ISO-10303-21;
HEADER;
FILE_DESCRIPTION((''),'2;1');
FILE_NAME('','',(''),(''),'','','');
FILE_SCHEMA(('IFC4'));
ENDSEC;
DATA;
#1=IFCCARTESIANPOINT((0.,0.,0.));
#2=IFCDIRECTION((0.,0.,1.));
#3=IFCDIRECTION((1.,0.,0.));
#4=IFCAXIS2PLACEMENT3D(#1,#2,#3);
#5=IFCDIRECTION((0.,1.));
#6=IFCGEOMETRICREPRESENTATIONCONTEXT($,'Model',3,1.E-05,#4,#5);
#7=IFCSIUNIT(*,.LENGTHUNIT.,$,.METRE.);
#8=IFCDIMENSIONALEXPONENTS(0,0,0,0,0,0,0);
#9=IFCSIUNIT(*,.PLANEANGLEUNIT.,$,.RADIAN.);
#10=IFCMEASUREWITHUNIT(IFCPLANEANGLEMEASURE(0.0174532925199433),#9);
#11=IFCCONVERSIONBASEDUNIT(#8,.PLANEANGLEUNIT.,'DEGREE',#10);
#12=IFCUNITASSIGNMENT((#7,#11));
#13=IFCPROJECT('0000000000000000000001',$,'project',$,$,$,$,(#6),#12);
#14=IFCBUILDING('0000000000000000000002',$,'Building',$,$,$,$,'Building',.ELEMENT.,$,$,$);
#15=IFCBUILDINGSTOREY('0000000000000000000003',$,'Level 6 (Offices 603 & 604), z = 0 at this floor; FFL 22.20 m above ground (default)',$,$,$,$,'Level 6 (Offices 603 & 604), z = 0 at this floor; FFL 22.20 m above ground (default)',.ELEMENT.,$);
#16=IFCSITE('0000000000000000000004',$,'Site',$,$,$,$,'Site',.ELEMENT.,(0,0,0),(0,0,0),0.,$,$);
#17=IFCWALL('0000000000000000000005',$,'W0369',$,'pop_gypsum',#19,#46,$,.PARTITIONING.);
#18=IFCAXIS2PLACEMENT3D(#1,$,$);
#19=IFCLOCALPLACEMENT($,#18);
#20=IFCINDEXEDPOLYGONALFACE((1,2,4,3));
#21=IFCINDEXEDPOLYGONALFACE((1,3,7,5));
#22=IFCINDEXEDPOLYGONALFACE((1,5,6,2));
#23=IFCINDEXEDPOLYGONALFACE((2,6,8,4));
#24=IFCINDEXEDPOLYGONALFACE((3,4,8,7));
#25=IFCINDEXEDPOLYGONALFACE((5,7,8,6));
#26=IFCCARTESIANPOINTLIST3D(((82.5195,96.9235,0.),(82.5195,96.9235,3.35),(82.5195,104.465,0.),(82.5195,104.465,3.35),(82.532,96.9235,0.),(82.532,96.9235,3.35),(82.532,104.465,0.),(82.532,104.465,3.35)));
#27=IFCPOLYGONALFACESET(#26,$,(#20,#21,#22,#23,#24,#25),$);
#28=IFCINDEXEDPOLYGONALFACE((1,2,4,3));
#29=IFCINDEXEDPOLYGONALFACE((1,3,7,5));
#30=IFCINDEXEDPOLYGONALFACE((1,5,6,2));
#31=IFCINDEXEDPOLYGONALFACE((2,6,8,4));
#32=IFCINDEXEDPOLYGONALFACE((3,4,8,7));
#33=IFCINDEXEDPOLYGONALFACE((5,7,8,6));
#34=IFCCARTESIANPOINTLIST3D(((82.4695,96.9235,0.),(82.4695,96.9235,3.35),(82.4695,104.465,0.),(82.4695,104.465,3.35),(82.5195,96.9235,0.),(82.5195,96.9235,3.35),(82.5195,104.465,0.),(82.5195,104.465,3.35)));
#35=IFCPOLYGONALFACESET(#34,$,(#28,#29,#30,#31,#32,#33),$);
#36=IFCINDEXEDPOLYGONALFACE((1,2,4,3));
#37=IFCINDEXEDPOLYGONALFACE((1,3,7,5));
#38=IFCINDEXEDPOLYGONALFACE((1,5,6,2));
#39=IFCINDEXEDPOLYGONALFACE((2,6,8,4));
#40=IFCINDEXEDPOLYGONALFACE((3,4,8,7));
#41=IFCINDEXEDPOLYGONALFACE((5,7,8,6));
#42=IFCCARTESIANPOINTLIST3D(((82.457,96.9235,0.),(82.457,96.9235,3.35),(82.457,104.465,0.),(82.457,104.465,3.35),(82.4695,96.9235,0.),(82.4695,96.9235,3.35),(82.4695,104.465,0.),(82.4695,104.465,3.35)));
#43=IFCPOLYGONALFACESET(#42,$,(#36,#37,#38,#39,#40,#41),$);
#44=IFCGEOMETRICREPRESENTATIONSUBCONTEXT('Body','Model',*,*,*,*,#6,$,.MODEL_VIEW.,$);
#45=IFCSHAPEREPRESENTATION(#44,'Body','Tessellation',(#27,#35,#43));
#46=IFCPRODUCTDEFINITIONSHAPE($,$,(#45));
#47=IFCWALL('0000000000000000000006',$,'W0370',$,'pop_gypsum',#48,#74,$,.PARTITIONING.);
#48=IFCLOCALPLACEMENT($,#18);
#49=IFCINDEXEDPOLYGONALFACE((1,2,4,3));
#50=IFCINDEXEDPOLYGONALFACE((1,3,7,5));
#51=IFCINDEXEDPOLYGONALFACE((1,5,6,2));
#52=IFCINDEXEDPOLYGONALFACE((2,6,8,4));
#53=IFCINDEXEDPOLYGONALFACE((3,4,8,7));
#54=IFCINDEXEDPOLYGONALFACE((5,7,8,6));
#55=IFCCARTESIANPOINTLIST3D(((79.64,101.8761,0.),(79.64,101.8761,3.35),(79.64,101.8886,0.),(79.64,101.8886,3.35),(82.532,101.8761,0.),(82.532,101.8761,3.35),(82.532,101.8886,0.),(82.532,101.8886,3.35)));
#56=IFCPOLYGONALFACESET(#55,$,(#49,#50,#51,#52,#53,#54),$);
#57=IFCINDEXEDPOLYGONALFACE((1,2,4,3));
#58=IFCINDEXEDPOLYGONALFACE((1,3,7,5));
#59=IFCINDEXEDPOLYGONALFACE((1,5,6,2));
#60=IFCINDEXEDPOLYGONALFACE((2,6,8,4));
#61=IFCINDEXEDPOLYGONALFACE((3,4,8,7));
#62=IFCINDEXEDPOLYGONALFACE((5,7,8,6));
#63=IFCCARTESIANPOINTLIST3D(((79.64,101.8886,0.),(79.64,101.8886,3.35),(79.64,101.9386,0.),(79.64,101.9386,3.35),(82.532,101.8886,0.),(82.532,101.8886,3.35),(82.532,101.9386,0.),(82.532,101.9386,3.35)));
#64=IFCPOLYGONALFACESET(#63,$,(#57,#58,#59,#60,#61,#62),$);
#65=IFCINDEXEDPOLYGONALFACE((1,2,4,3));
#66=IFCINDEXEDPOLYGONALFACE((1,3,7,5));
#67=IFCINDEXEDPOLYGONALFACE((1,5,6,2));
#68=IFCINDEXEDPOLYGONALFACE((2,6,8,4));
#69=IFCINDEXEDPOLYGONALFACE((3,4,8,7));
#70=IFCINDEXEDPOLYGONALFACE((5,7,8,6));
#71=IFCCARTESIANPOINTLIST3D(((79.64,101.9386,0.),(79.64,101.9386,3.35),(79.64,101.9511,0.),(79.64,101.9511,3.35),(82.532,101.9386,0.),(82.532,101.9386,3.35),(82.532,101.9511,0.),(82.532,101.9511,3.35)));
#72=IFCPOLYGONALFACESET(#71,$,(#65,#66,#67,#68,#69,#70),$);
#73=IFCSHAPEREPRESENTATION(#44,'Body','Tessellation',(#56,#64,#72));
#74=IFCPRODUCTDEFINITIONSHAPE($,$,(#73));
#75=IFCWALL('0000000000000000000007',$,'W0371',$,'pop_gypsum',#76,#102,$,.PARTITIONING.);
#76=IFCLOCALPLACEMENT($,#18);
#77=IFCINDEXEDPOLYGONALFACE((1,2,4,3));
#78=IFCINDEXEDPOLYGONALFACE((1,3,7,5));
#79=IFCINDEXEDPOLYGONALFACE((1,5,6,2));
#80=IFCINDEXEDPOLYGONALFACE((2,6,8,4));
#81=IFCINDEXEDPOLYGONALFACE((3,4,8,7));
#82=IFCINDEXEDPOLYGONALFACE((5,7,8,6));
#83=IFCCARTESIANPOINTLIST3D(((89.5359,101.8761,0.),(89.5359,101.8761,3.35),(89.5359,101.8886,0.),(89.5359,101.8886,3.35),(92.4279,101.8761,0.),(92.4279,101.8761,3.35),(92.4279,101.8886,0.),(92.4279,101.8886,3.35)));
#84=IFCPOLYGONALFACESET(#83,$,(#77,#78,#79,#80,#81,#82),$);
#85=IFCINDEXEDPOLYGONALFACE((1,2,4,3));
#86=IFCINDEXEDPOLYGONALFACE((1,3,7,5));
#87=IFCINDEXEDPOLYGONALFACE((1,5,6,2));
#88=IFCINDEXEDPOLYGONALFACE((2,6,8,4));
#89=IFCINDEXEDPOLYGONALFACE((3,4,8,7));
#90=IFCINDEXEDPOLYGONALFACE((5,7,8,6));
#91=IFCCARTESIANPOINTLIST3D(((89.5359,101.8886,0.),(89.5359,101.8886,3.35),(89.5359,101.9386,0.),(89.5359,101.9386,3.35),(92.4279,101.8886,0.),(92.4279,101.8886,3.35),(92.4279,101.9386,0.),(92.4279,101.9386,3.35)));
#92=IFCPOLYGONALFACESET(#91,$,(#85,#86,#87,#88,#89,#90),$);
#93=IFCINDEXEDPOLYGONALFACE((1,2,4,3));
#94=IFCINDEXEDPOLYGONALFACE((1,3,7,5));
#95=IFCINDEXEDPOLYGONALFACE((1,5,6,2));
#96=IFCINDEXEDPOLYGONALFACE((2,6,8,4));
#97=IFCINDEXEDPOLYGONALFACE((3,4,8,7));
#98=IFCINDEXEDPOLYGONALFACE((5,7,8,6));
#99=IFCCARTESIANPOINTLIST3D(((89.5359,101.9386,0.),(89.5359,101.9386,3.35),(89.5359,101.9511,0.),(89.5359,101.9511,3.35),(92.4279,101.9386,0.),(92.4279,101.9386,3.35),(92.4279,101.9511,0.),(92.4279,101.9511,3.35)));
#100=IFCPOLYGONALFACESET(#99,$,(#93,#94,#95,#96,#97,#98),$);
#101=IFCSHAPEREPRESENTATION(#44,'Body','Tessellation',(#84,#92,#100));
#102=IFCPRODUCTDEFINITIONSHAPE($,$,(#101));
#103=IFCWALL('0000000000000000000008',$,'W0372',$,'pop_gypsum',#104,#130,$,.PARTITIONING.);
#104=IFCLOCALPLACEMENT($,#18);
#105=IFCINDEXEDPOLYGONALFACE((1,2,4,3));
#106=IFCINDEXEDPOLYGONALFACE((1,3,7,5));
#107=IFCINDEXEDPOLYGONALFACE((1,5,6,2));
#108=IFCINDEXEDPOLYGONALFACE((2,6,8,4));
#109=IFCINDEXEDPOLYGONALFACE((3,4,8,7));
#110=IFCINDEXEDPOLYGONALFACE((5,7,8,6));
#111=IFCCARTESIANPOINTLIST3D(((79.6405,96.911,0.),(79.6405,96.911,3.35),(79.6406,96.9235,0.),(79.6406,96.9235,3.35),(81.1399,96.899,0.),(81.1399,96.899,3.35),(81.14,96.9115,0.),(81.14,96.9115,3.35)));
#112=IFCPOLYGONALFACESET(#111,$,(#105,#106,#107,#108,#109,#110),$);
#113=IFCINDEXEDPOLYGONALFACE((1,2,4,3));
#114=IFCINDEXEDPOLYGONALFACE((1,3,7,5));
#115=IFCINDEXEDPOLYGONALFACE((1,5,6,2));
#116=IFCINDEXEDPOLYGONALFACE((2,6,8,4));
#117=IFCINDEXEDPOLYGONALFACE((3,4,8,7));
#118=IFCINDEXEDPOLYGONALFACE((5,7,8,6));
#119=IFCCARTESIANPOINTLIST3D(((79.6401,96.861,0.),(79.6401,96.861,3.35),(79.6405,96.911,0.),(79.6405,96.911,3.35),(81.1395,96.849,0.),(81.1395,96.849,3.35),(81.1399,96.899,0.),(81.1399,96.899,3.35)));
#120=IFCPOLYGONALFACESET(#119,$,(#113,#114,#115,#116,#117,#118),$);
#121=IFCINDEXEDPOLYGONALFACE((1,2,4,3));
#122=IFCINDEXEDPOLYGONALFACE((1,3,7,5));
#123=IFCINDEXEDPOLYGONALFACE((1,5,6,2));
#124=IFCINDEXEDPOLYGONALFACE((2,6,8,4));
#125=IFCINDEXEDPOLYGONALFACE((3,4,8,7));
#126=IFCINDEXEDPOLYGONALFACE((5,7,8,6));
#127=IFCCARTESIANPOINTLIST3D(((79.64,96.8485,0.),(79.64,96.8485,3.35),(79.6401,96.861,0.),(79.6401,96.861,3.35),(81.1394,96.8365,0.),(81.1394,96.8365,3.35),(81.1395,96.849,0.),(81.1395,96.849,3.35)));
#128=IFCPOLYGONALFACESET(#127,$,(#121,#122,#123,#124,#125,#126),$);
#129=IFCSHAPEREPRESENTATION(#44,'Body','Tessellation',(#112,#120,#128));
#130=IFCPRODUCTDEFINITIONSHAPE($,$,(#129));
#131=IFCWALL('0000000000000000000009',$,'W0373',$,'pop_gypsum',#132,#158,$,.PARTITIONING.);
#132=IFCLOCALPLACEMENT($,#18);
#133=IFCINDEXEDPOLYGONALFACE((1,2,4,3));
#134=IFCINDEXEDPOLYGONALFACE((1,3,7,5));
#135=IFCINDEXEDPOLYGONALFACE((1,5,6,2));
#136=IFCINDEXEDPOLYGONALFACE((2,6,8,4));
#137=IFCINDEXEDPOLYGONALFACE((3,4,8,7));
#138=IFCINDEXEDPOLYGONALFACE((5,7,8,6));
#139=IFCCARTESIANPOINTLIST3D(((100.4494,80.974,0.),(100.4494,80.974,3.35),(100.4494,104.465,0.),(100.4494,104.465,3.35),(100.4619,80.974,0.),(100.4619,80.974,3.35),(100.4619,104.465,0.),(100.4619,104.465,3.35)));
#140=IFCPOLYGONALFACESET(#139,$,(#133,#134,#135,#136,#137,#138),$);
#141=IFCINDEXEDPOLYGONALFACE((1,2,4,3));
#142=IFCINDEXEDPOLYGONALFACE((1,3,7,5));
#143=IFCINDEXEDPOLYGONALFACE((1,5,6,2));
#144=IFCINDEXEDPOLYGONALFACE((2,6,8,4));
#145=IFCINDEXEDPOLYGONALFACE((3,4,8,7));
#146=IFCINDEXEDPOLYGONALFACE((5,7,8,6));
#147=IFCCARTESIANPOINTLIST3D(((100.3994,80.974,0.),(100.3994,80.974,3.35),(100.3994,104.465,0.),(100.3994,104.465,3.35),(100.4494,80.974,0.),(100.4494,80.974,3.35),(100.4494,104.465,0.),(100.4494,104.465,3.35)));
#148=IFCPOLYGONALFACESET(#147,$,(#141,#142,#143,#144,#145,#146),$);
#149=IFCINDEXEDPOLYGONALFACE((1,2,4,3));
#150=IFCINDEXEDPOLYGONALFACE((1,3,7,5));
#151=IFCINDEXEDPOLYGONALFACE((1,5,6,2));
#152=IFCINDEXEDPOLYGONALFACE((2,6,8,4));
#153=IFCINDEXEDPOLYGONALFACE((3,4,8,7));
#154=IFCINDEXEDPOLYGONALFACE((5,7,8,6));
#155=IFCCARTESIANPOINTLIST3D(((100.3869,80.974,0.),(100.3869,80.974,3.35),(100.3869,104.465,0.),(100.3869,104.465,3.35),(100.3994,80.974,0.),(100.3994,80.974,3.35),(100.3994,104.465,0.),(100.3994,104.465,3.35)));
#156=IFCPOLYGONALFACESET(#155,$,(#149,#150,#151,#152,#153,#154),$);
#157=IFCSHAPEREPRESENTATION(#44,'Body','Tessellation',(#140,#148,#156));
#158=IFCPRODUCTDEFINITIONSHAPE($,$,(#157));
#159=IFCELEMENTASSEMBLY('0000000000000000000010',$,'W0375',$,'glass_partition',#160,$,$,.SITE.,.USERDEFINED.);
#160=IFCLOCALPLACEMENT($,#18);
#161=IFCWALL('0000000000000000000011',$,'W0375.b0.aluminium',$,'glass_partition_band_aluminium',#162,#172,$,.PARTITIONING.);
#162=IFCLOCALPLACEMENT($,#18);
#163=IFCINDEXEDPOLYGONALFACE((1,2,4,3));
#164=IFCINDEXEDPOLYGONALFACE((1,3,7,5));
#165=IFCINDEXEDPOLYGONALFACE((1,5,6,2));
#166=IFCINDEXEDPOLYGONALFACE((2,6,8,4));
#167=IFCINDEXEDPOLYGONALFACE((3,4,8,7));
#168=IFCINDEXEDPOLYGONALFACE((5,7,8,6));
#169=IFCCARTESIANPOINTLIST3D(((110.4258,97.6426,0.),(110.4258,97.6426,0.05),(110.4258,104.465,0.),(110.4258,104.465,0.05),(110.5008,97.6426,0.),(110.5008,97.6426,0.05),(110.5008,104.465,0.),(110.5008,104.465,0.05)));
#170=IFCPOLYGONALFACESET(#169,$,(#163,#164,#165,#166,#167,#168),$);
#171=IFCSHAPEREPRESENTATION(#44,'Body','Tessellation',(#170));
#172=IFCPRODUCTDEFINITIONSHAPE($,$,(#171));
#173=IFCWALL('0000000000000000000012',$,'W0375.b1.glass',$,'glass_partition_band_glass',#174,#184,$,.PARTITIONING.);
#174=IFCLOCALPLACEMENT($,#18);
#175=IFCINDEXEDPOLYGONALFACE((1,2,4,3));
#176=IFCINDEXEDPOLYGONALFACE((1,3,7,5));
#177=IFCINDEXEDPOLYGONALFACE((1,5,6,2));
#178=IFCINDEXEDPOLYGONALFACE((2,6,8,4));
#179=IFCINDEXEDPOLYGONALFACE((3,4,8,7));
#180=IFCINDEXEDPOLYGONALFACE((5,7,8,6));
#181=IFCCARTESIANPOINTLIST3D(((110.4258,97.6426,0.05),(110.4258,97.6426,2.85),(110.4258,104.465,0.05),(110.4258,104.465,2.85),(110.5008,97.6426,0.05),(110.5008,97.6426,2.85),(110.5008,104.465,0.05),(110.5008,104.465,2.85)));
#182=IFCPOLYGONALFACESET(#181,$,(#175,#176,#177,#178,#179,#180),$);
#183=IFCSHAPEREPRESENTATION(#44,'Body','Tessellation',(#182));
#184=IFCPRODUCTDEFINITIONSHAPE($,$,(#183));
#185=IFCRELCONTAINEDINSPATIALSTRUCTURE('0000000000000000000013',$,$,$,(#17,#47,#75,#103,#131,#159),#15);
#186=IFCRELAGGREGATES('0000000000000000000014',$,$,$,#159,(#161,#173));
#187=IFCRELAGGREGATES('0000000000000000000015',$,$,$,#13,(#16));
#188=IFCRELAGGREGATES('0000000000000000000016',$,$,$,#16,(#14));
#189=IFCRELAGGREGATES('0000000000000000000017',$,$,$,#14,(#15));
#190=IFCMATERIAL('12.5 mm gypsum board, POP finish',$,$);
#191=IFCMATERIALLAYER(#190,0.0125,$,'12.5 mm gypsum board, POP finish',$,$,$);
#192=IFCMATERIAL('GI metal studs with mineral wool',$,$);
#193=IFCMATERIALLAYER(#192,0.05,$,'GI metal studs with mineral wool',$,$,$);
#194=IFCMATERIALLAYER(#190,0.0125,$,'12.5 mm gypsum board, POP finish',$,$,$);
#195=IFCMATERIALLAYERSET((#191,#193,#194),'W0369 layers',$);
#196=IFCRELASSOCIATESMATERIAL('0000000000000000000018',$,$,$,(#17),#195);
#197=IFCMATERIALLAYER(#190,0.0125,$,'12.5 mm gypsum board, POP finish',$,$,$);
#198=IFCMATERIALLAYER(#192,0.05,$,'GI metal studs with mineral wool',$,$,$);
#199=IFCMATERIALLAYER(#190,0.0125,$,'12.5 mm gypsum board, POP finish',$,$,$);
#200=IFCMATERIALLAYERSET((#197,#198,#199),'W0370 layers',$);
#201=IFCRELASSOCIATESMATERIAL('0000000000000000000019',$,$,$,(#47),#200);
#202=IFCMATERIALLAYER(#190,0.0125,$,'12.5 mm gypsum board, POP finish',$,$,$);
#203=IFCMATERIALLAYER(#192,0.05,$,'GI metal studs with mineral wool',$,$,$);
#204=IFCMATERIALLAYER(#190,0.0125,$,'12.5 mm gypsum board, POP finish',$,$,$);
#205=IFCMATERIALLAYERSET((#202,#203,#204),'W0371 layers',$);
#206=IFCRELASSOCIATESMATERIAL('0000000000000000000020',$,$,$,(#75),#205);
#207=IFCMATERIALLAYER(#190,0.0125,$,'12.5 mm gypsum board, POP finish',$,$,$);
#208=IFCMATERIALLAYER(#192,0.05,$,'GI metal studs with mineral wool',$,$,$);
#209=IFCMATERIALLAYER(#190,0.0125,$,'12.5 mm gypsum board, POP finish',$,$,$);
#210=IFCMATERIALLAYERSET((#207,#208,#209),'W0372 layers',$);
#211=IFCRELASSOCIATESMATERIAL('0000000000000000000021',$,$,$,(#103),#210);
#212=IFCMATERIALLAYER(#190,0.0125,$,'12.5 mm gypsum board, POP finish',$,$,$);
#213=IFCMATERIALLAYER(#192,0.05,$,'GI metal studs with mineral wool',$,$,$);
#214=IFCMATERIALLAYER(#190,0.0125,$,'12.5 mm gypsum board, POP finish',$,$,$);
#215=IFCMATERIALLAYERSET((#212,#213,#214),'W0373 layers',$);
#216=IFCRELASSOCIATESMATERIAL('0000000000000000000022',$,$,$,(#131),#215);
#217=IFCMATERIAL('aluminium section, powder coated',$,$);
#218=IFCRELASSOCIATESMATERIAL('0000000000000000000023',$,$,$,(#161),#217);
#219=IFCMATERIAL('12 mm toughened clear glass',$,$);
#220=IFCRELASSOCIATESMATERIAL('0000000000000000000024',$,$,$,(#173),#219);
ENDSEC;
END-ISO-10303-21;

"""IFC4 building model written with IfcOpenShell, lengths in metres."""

from ifc_helpers import new_model, entity, si_unit, converted_unit, direction, frame, frame_2d, origin_with_axes, place, context, subcontext, project, spatial, rectangle, extrude, material, layer, layer_set, layer_usage, element, aggregate, save


model = new_model("IFC4")

# Units and contexts
model_context = context("Model", 3, precision=1e-05, world=origin_with_axes(), true_north=direction((0.0, 1.0)))
body_context = subcontext(model_context, "Body", "Model", "MODEL_VIEW")
ifc_project = project(units=[si_unit("LENGTHUNIT", "METRE"), converted_unit("PLANEANGLEUNIT", "DEGREE", entity("IfcPlaneAngleMeasure", 0.0174532925199433), si_unit("PLANEANGLEUNIT", "RADIAN"), dimensions=[0, 0, 0, 0, 0, 0, 0])], contexts=[model_context])

# Site, building, storey
site = spatial("IfcSite", under=ifc_project, Name="Site", LongName="Site", CompositionType="ELEMENT", RefLatitude=(0, 0, 0), RefLongitude=(0, 0, 0), RefElevation=0.0)
building = spatial("IfcBuilding", under=site, Name="Building", LongName="Building", CompositionType="ELEMENT")
storey = spatial("IfcBuildingStorey", under=building, Name="Level 6 (Offices 603 & 604), z = 0 at this floor; FFL 22.20 m above ground (default)", LongName="Level 6 (Offices 603 & 604), z = 0 at this floor; FFL 22.20 m above ground (default)", CompositionType="ELEMENT")

# Shared definitions
ifc_material_1 = material(Name="aluminium section, powder coated")
placement = place(None, origin_with_axes())

# Shared definitions
ifc_material_2 = material(Name="12 mm toughened clear glass")

# Shared definitions
ifc_material_3 = material(Name="12.5 mm gypsum board, POP finish")
ifc_material_4 = material(Name="GI metal studs with mineral wool")

# Walls
ifc_layer_1 = layer(ifc_material_3, 0.0125, Name="12.5 mm gypsum board, POP finish")
ifc_layer_2 = layer(ifc_material_4, 0.05, Name="GI metal studs with mineral wool")
ifc_layer_3 = layer(ifc_material_3, 0.0125, Name="12.5 mm gypsum board, POP finish")
ifc_layer_set_1 = layer_set([ifc_layer_1, ifc_layer_2, ifc_layer_3], Name="W0369 layers")
ifc_layer_usage_1 = layer_usage(ifc_layer_set_1, "AXIS2", "POSITIVE", -0.0375)
element("IfcWall", 1, at=placement, inside=storey, material=ifc_layer_usage_1, Name="W0369", ObjectType="pop_gypsum", PredefinedType="PARTITIONING", context=body_context, shape_type="SweptSolid", body=[
    extrude(rectangle(XDim=7.5415, YDim=0.0125, at=frame_2d((0.0, 0.0), x_axis=(0.0, 1.0))), frame((82.5258, 100.6942, 0.0), z_axis=(0.0, 0.0, 1.0), x_axis=(1.0, 0.0, 0.0)), (0.0, 0.0, 1.0), 3.35),
    extrude(rectangle(XDim=7.5415, YDim=0.05, at=frame_2d((-0.0312, 0.0), x_axis=(0.0, 1.0))), frame((82.5258, 100.6942, 0.0), z_axis=(0.0, 0.0, 1.0), x_axis=(1.0, 0.0, 0.0)), (0.0, 0.0, 1.0), 3.35),
    extrude(rectangle(XDim=7.5415, YDim=0.0125, at=frame_2d((-0.0625, 0.0), x_axis=(0.0, 1.0))), frame((82.5258, 100.6942, 0.0), z_axis=(0.0, 0.0, 1.0), x_axis=(1.0, 0.0, 0.0)), (0.0, 0.0, 1.0), 3.35),
])
ifc_layer_4 = layer(ifc_material_3, 0.0125, Name="12.5 mm gypsum board, POP finish")
ifc_layer_5 = layer(ifc_material_4, 0.05, Name="GI metal studs with mineral wool")
ifc_layer_6 = layer(ifc_material_3, 0.0125, Name="12.5 mm gypsum board, POP finish")
ifc_layer_set_2 = layer_set([ifc_layer_4, ifc_layer_5, ifc_layer_6], Name="W0370 layers")
ifc_layer_usage_2 = layer_usage(ifc_layer_set_2, "AXIS2", "POSITIVE", -0.0375)
element("IfcWall", 2, at=placement, inside=storey, material=ifc_layer_usage_2, Name="W0370", ObjectType="pop_gypsum", PredefinedType="PARTITIONING", context=body_context, shape_type="SweptSolid", body=[
    extrude(rectangle(XDim=2.892, YDim=0.0125, at=frame_2d((0.0, 0.0), x_axis=(1.0, 0.0))), frame((81.086, 101.8824, 0.0), z_axis=(0.0, 0.0, 1.0), x_axis=(1.0, 0.0, 0.0)), (0.0, 0.0, 1.0), 3.35),
    extrude(rectangle(XDim=2.892, YDim=0.05, at=frame_2d((0.0, 0.0313), x_axis=(1.0, 0.0))), frame((81.086, 101.8824, 0.0), z_axis=(0.0, 0.0, 1.0), x_axis=(1.0, 0.0, 0.0)), (0.0, 0.0, 1.0), 3.35),
    extrude(rectangle(XDim=2.892, YDim=0.0125, at=frame_2d((0.0, 0.0625), x_axis=(1.0, 0.0))), frame((81.086, 101.8824, 0.0), z_axis=(0.0, 0.0, 1.0), x_axis=(1.0, 0.0, 0.0)), (0.0, 0.0, 1.0), 3.35),
])
ifc_layer_7 = layer(ifc_material_3, 0.0125, Name="12.5 mm gypsum board, POP finish")
ifc_layer_8 = layer(ifc_material_4, 0.05, Name="GI metal studs with mineral wool")
ifc_layer_9 = layer(ifc_material_3, 0.0125, Name="12.5 mm gypsum board, POP finish")
ifc_layer_set_3 = layer_set([ifc_layer_7, ifc_layer_8, ifc_layer_9], Name="W0371 layers")
ifc_layer_usage_3 = layer_usage(ifc_layer_set_3, "AXIS2", "POSITIVE", -0.0375)
element("IfcWall", 3, at=placement, inside=storey, material=ifc_layer_usage_3, Name="W0371", ObjectType="pop_gypsum", PredefinedType="PARTITIONING", context=body_context, shape_type="SweptSolid", body=[
    extrude(rectangle(XDim=2.892, YDim=0.0125, at=frame_2d((0.0, 0.0), x_axis=(1.0, 0.0))), frame((90.9819, 101.8824, 0.0), z_axis=(0.0, 0.0, 1.0), x_axis=(1.0, 0.0, 0.0)), (0.0, 0.0, 1.0), 3.35),
    extrude(rectangle(XDim=2.892, YDim=0.05, at=frame_2d((0.0, 0.0313), x_axis=(1.0, 0.0))), frame((90.9819, 101.8824, 0.0), z_axis=(0.0, 0.0, 1.0), x_axis=(1.0, 0.0, 0.0)), (0.0, 0.0, 1.0), 3.35),
    extrude(rectangle(XDim=2.892, YDim=0.0125, at=frame_2d((0.0, 0.0625), x_axis=(1.0, 0.0))), frame((90.9819, 101.8824, 0.0), z_axis=(0.0, 0.0, 1.0), x_axis=(1.0, 0.0, 0.0)), (0.0, 0.0, 1.0), 3.35),
])
ifc_layer_10 = layer(ifc_material_3, 0.0125, Name="12.5 mm gypsum board, POP finish")
ifc_layer_11 = layer(ifc_material_4, 0.05, Name="GI metal studs with mineral wool")
ifc_layer_12 = layer(ifc_material_3, 0.0125, Name="12.5 mm gypsum board, POP finish")
ifc_layer_set_4 = layer_set([ifc_layer_10, ifc_layer_11, ifc_layer_12], Name="W0372 layers")
ifc_layer_usage_4 = layer_usage(ifc_layer_set_4, "AXIS2", "POSITIVE", -0.0375)
element("IfcWall", 4, at=placement, inside=storey, material=ifc_layer_usage_4, Name="W0372", ObjectType="pop_gypsum", PredefinedType="PARTITIONING", context=body_context, shape_type="SweptSolid", body=[
    extrude(rectangle(XDim=1.4994, YDim=0.0125, at=frame_2d((0.0, 0.0), x_axis=(0.999968, -0.008003))), frame((80.3903, 96.9112, 0.0), z_axis=(0.0, 0.0, 1.0), x_axis=(1.0, 0.0, 0.0)), (0.0, 0.0, 1.0), 3.35),
    extrude(rectangle(XDim=1.4994, YDim=0.05, at=frame_2d((-0.0003, -0.0312), x_axis=(0.999968, -0.008003))), frame((80.3903, 96.9112, 0.0), z_axis=(0.0, 0.0, 1.0), x_axis=(1.0, 0.0, 0.0)), (0.0, 0.0, 1.0), 3.35),
    extrude(rectangle(XDim=1.4994, YDim=0.0125, at=frame_2d((-0.0005, -0.0625), x_axis=(0.999968, -0.008003))), frame((80.3903, 96.9112, 0.0), z_axis=(0.0, 0.0, 1.0), x_axis=(1.0, 0.0, 0.0)), (0.0, 0.0, 1.0), 3.35),
])
ifc_layer_13 = layer(ifc_material_3, 0.0125, Name="12.5 mm gypsum board, POP finish")
ifc_layer_14 = layer(ifc_material_4, 0.05, Name="GI metal studs with mineral wool")
ifc_layer_15 = layer(ifc_material_3, 0.0125, Name="12.5 mm gypsum board, POP finish")
ifc_layer_set_5 = layer_set([ifc_layer_13, ifc_layer_14, ifc_layer_15], Name="W0373 layers")
ifc_layer_usage_5 = layer_usage(ifc_layer_set_5, "AXIS2", "POSITIVE", -0.0375)
element("IfcWall", 5, at=placement, inside=storey, material=ifc_layer_usage_5, Name="W0373", ObjectType="pop_gypsum", PredefinedType="PARTITIONING", context=body_context, shape_type="SweptSolid", body=[
    extrude(rectangle(XDim=23.491, YDim=0.0125, at=frame_2d((0.0, 0.0), x_axis=(0.0, 1.0))), frame((100.4557, 92.7195, 0.0), z_axis=(0.0, 0.0, 1.0), x_axis=(1.0, 0.0, 0.0)), (0.0, 0.0, 1.0), 3.35),
    extrude(rectangle(XDim=23.491, YDim=0.05, at=frame_2d((-0.0312, 0.0), x_axis=(0.0, 1.0))), frame((100.4557, 92.7195, 0.0), z_axis=(0.0, 0.0, 1.0), x_axis=(1.0, 0.0, 0.0)), (0.0, 0.0, 1.0), 3.35),
    extrude(rectangle(XDim=23.491, YDim=0.0125, at=frame_2d((-0.0625, 0.0), x_axis=(0.0, 1.0))), frame((100.4557, 92.7195, 0.0), z_axis=(0.0, 0.0, 1.0), x_axis=(1.0, 0.0, 0.0)), (0.0, 0.0, 1.0), 3.35),
])

# Element assembly, walls
assembly_1 = element("IfcElementAssembly", 6, inside=storey, Name="W0375", ObjectType="glass_partition", AssemblyPlace="SITE", PredefinedType="USERDEFINED")
wall_1 = element("IfcWall", 7, at=placement, material=ifc_material_1, Name="W0375.b0.aluminium", ObjectType="glass_partition_band_aluminium", PredefinedType="PARTITIONING", context=body_context, shape_type="SweptSolid", body=[
    extrude(rectangle(XDim=6.8224, YDim=0.075, at=frame_2d((0.0, 0.0), x_axis=(0.0, 1.0))), frame((110.4633, 101.0538, 0.0), z_axis=(0.0, 0.0, 1.0), x_axis=(1.0, 0.0, 0.0)), (0.0, 0.0, 1.0), 0.05),
])
wall_2 = element("IfcWall", 8, at=placement, material=ifc_material_2, Name="W0375.b1.glass", ObjectType="glass_partition_band_glass", PredefinedType="PARTITIONING", context=body_context, shape_type="SweptSolid", body=[
    extrude(rectangle(XDim=6.8224, YDim=0.075, at=frame_2d((0.0, 0.0), x_axis=(0.0, 1.0))), frame((110.4633, 101.0538, 0.05), z_axis=(0.0, 0.0, 1.0), x_axis=(1.0, 0.0, 0.0)), (0.0, 0.0, 1.0), 2.8),
])
aggregate(assembly_1, [wall_1, wall_2])

save(model, "model.ifc")
